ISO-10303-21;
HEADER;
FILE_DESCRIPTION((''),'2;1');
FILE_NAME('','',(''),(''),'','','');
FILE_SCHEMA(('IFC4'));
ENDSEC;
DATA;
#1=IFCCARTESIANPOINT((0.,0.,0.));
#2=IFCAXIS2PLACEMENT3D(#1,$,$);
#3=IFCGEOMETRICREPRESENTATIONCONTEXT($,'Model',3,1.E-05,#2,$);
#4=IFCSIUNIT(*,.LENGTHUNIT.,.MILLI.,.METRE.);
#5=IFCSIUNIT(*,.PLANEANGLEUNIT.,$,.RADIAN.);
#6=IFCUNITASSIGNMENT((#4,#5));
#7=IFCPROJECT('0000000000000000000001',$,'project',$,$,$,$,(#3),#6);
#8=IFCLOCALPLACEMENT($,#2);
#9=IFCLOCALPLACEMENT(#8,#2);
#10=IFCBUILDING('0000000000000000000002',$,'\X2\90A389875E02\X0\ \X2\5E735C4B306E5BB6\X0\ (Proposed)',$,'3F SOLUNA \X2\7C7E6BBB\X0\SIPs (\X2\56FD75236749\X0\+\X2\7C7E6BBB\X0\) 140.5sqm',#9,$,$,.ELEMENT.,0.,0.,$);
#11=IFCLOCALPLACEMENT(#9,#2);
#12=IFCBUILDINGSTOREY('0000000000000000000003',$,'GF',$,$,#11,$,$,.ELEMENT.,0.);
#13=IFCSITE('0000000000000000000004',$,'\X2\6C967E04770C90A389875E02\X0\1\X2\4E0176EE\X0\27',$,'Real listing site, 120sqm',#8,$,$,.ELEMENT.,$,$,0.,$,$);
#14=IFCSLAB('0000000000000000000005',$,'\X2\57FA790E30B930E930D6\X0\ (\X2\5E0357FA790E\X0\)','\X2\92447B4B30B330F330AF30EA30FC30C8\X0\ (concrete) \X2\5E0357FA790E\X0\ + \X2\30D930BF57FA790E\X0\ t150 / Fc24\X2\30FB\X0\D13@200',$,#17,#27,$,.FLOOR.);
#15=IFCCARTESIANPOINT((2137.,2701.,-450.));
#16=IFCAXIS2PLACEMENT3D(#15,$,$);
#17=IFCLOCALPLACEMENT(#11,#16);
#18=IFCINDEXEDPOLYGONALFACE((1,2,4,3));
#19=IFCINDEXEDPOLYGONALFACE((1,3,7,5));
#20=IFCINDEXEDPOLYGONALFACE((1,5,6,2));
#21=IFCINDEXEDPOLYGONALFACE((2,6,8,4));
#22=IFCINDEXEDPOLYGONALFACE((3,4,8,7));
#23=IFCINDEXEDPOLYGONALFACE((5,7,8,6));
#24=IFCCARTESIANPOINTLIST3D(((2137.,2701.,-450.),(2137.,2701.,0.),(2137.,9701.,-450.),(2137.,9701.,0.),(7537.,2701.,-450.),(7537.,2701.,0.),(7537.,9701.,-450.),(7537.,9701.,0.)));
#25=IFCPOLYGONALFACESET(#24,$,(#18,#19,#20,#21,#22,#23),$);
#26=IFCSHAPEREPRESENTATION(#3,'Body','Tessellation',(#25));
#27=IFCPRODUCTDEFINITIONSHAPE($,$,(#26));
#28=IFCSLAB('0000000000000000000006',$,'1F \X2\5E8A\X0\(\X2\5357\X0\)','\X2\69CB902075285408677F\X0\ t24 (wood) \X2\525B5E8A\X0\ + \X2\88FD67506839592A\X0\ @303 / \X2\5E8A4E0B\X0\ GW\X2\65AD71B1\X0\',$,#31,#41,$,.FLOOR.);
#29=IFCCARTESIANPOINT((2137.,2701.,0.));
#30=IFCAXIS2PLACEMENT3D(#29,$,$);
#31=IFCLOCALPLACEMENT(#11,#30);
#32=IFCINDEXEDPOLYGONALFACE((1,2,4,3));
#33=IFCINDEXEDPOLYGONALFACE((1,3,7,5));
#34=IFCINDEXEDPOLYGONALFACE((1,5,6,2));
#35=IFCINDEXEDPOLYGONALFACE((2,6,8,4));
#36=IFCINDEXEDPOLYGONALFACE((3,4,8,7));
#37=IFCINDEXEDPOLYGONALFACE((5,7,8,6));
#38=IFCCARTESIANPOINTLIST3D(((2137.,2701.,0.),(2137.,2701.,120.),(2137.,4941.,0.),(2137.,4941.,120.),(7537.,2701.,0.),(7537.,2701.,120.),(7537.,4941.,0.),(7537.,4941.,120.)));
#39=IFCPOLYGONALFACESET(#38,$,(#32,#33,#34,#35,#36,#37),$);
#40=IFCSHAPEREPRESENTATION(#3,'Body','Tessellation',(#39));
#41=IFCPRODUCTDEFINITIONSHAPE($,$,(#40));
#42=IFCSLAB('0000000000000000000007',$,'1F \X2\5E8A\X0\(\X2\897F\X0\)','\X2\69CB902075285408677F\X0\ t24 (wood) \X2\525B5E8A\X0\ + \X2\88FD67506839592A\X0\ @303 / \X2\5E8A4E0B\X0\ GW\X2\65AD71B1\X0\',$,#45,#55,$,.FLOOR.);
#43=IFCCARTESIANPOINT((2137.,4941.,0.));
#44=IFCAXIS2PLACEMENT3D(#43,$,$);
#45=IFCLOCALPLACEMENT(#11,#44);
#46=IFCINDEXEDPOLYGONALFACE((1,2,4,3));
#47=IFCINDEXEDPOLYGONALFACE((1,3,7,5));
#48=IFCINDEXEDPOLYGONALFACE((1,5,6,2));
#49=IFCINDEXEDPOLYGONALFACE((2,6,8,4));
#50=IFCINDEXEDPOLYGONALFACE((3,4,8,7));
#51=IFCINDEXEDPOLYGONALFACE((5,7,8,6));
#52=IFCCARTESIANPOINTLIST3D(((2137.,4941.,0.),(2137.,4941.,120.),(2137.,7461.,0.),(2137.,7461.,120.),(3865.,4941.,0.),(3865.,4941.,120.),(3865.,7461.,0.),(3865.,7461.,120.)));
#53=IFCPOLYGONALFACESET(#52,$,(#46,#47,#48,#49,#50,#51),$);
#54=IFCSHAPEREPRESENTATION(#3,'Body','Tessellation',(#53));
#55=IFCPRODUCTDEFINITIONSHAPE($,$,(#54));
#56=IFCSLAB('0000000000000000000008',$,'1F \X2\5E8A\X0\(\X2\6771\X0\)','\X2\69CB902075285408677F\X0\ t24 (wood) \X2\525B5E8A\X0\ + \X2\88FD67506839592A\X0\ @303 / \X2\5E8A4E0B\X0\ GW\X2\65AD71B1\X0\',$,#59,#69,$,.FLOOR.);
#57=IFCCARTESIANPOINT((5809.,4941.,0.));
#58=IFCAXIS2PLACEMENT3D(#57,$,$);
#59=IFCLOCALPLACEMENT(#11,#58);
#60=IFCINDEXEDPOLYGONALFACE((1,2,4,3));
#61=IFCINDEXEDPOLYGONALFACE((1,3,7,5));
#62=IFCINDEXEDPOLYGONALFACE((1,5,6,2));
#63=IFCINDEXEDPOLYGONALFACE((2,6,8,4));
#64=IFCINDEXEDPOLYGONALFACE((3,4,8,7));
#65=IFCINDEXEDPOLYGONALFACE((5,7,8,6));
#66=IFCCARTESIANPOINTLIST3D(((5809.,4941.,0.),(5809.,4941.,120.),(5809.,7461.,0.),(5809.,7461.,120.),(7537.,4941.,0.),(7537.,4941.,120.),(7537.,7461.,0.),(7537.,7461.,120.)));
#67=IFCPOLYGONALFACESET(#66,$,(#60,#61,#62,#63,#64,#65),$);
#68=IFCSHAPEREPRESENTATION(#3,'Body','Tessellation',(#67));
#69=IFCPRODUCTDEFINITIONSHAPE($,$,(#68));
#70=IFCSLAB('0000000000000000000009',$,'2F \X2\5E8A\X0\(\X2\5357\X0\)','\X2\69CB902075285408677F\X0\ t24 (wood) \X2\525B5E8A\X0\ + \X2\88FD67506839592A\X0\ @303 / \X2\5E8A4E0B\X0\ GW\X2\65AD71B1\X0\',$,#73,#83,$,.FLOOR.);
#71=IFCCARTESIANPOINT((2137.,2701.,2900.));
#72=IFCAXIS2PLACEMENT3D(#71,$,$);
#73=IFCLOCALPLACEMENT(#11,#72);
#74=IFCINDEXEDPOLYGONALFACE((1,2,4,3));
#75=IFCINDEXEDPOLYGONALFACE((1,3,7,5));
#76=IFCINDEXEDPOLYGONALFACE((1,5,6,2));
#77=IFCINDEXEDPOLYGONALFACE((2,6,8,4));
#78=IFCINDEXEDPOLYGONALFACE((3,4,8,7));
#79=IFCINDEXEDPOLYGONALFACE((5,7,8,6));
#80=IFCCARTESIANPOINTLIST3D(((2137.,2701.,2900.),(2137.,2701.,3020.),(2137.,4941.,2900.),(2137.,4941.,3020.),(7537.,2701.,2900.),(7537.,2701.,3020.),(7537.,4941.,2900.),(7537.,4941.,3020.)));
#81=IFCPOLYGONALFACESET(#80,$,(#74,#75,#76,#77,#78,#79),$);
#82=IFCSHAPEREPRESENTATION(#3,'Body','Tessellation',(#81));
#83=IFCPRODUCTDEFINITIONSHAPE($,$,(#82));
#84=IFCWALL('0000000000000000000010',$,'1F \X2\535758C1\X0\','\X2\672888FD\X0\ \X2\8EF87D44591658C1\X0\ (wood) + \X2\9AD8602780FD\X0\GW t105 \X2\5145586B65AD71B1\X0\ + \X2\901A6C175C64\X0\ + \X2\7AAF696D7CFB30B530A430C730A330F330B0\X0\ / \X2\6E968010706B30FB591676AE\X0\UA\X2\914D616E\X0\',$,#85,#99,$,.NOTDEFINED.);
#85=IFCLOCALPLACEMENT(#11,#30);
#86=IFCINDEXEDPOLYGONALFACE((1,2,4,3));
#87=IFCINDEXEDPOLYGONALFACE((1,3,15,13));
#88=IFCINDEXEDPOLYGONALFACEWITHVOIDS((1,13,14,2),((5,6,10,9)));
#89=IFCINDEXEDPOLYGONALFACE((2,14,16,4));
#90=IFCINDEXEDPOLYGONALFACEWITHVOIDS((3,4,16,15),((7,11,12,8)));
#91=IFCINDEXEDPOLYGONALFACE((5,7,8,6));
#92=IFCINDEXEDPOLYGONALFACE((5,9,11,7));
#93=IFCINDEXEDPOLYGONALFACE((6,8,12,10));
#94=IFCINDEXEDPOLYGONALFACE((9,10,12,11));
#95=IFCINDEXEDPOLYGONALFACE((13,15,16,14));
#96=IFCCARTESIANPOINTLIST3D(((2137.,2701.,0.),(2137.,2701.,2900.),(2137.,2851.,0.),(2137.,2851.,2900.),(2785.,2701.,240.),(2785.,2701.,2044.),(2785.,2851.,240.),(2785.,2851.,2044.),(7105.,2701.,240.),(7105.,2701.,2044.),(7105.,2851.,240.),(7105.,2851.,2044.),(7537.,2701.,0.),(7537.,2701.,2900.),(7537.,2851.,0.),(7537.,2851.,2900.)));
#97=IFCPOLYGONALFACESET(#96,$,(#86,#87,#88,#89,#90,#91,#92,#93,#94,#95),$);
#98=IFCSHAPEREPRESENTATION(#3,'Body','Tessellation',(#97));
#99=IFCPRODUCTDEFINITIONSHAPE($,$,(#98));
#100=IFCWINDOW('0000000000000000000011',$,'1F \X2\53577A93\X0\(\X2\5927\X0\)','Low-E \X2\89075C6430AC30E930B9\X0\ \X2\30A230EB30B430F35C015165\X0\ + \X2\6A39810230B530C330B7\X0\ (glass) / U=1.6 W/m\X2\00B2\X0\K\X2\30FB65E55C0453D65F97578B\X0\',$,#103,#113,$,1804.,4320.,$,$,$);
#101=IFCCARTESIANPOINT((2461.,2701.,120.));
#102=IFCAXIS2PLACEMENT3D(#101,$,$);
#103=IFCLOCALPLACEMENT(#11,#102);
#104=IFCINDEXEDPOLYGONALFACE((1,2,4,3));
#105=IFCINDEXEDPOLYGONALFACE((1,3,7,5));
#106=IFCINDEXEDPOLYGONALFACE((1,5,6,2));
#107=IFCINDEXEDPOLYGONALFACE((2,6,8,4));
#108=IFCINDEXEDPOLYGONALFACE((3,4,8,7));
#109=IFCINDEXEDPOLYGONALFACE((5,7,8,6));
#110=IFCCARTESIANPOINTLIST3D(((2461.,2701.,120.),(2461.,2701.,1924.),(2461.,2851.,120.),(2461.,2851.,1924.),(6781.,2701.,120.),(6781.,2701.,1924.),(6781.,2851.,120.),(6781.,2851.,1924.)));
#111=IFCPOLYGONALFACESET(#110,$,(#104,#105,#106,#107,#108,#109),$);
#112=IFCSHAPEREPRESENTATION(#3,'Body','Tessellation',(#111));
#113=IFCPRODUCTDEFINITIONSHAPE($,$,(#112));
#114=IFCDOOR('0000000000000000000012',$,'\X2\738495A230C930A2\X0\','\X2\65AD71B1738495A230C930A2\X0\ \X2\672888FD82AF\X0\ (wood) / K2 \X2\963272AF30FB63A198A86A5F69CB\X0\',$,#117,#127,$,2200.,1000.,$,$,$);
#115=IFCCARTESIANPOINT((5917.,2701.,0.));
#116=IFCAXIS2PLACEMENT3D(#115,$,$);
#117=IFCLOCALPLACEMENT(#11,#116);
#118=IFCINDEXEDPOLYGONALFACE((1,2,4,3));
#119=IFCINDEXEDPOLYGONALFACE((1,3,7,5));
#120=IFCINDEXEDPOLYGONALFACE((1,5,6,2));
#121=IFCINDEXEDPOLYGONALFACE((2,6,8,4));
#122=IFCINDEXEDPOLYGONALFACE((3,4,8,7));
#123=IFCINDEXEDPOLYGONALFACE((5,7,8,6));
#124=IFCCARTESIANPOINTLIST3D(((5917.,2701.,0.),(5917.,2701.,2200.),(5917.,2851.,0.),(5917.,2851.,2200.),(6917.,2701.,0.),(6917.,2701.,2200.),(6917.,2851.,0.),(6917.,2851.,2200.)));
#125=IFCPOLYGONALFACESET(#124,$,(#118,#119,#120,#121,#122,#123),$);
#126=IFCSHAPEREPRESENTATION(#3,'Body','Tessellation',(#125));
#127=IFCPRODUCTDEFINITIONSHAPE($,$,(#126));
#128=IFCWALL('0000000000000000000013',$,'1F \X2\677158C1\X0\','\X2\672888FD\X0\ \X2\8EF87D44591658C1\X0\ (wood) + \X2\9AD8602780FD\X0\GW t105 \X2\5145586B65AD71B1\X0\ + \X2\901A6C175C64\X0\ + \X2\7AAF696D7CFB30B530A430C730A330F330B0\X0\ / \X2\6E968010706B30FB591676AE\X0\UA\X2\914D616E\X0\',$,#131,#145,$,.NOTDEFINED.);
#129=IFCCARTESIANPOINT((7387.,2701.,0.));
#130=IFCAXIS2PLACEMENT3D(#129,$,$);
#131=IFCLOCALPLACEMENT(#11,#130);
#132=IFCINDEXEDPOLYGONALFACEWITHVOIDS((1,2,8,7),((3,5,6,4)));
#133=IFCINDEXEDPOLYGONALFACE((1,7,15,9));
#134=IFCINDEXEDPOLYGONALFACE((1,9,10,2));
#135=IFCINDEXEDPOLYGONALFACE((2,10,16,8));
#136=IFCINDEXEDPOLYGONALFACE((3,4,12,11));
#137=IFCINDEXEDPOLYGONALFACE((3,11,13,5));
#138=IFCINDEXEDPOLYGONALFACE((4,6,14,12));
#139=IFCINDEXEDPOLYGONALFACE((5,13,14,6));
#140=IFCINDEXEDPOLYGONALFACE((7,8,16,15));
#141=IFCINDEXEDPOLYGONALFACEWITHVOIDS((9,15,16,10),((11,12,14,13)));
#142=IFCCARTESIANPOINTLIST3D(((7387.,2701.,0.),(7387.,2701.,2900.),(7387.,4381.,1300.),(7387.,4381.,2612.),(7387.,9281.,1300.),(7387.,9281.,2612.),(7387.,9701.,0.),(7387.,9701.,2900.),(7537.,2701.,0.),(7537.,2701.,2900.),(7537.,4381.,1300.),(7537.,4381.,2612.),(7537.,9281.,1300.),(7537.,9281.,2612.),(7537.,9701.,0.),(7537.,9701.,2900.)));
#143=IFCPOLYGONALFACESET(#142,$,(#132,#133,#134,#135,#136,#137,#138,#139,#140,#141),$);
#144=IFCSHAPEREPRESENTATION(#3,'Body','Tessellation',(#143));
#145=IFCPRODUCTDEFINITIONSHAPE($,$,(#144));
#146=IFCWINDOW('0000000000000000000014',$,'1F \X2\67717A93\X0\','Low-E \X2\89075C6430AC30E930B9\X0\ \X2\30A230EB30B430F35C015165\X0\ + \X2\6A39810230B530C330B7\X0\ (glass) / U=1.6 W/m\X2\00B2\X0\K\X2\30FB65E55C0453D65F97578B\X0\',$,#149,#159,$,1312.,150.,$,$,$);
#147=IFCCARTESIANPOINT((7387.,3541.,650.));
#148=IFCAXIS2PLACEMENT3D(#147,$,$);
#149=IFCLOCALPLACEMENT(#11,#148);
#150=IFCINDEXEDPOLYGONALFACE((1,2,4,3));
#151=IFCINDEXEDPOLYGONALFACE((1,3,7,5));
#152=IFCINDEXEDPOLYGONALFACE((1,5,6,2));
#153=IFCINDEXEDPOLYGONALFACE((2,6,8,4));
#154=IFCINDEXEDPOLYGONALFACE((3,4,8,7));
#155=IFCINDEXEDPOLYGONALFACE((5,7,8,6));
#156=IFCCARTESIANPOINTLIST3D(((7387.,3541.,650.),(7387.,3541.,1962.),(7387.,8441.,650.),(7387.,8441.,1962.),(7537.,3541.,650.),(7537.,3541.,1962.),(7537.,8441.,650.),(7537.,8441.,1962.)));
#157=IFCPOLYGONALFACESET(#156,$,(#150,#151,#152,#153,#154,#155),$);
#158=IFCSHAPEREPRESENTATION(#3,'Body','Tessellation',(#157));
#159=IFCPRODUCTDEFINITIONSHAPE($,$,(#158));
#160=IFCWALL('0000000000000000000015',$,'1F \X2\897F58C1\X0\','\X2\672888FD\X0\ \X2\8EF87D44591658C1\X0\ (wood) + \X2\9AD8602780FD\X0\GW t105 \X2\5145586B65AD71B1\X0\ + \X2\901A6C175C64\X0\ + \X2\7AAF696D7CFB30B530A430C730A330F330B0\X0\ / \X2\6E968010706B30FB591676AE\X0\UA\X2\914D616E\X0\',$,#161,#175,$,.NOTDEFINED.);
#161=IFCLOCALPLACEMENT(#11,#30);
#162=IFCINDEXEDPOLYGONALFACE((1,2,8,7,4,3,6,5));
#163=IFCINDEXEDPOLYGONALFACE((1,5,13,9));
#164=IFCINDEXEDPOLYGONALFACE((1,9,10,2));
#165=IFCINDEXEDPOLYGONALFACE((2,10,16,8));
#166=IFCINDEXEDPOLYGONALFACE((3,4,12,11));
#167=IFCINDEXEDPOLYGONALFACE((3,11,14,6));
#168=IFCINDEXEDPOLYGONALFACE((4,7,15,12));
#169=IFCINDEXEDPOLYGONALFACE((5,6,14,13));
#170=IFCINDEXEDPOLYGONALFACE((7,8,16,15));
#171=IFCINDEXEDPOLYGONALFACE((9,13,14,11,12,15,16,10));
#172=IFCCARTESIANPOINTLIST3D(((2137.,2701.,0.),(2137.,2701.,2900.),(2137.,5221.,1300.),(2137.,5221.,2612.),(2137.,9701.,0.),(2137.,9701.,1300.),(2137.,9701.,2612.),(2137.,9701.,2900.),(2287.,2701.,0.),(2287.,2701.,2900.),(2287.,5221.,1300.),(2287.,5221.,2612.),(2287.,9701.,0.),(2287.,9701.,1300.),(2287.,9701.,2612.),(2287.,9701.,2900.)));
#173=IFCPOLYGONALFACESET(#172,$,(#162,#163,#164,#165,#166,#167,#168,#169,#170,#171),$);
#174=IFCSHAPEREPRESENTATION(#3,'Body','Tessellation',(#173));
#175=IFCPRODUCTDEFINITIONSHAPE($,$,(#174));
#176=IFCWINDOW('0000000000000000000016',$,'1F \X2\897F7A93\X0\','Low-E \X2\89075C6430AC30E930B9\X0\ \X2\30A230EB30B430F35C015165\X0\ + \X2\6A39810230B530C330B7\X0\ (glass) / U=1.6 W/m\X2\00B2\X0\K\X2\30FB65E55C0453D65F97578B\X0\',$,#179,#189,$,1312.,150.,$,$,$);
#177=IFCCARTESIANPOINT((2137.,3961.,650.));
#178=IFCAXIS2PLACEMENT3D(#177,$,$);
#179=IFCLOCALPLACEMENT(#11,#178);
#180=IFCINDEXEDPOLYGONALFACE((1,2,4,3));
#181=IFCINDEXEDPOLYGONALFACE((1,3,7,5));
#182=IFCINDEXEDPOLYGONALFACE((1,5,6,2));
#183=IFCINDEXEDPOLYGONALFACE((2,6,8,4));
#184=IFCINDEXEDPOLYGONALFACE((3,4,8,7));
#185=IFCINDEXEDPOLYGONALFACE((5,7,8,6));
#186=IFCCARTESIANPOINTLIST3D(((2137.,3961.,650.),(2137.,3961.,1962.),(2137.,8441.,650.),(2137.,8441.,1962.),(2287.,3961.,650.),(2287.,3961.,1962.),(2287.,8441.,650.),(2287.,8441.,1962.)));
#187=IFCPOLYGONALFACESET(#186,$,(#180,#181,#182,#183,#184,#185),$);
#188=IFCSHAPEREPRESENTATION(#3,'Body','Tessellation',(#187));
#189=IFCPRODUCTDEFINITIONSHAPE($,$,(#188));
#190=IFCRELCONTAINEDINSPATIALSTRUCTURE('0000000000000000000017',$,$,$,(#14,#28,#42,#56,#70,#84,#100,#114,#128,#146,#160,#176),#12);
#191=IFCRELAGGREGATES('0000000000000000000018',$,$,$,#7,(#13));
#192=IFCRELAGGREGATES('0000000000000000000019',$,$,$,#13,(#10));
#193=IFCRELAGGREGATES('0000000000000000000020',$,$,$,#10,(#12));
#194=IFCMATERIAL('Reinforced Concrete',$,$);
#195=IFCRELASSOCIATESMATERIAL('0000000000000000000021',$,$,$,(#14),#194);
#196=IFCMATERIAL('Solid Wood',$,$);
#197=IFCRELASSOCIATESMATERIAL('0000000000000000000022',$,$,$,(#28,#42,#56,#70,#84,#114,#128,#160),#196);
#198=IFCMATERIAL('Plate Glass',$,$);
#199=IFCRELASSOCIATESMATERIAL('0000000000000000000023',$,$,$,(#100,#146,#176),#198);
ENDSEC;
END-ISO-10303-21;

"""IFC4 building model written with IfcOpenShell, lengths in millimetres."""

from ifc_helpers import new_model, si_unit, frame, frame_2d, origin, place, context, project, spatial, rectangle, extrude, material, element, fill, save


model = new_model("IFC4")

# Units and contexts
model_context = context("Model", 3, precision=1e-05, world=origin())
ifc_project = project(units=[si_unit("LENGTHUNIT", "METRE", prefix="MILLI"), si_unit("PLANEANGLEUNIT", "RADIAN")], contexts=[model_context])

# Site, building, storey
site_placement = place(None, origin())
site = spatial("IfcSite", under=ifc_project, at=site_placement, Name="沖縄県那覇市1丁目27", ObjectType="Real listing site, 120sqm", CompositionType="ELEMENT", RefElevation=0.0)
building_placement = place(site_placement, origin())
building = spatial("IfcBuilding", under=site, at=building_placement, Name="那覇市 平屋の家 (Proposed)", ObjectType="3F SOLUNA 籾殻SIPs (国産杉+籾殻) 140.5sqm", CompositionType="ELEMENT", ElevationOfRefHeight=0.0, ElevationOfTerrain=0.0)
storey_placement = place(building_placement, origin())
storey = spatial("IfcBuildingStorey", under=building, at=storey_placement, Name="GF", CompositionType="ELEMENT", Elevation=0.0)

# Slabs
ifc_material_1 = material(Name="Reinforced Concrete")
slab_1_placement = place(storey_placement, frame((2137.0, 2701.0, -450.0)))
element("IfcSlab", 1, at=slab_1_placement, inside=storey, material=ifc_material_1, Name="基礎スラブ (布基礎)", Description="鉄筋コンクリート (concrete) 布基礎 + ベタ基礎 t150 / Fc24・D13@200", PredefinedType="FLOOR", context=model_context, shape_type="SweptSolid", body=[
    extrude(rectangle(XDim=5400.0, YDim=7000.0, at=frame_2d((2700.0, 3500.0))), frame((2137.0, 2701.0, -450.0)), (0.0, 0.0, 1.0), 450.0),
])
ifc_material_2 = material(Name="Solid Wood")
slab_2_placement = place(storey_placement, frame((2137.0, 2701.0, 0.0)))
element("IfcSlab", 2, at=slab_2_placement, inside=storey, material=ifc_material_2, Name="1F 床(南)", Description="構造用合板 t24 (wood) 剛床 + 製材根太 @303 / 床下 GW断熱", PredefinedType="FLOOR", context=model_context, shape_type="SweptSolid", body=[
    extrude(rectangle(XDim=5400.0, YDim=2240.0, at=frame_2d((2700.0, 1120.0))), frame((2137.0, 2701.0, 0.0)), (0.0, 0.0, 1.0), 120.0),
])
slab_3_placement = place(storey_placement, frame((2137.0, 4941.0, 0.0)))
element("IfcSlab", 3, at=slab_3_placement, inside=storey, material=ifc_material_2, Name="1F 床(西)", Description="構造用合板 t24 (wood) 剛床 + 製材根太 @303 / 床下 GW断熱", PredefinedType="FLOOR", context=model_context, shape_type="SweptSolid", body=[
    extrude(rectangle(XDim=1728.0, YDim=2520.0, at=frame_2d((864.0, 1260.0))), frame((2137.0, 4941.0, 0.0)), (0.0, 0.0, 1.0), 120.0),
])
slab_4_placement = place(storey_placement, frame((5809.0, 4941.0, 0.0)))
element("IfcSlab", 4, at=slab_4_placement, inside=storey, material=ifc_material_2, Name="1F 床(東)", Description="構造用合板 t24 (wood) 剛床 + 製材根太 @303 / 床下 GW断熱", PredefinedType="FLOOR", context=model_context, shape_type="SweptSolid", body=[
    extrude(rectangle(XDim=1728.0, YDim=2520.0, at=frame_2d((864.0, 1260.0))), frame((5809.0, 4941.0, 0.0)), (0.0, 0.0, 1.0), 120.0),
])
slab_5_placement = place(storey_placement, frame((2137.0, 2701.0, 2900.0)))
element("IfcSlab", 5, at=slab_5_placement, inside=storey, material=ifc_material_2, Name="2F 床(南)", Description="構造用合板 t24 (wood) 剛床 + 製材根太 @303 / 床下 GW断熱", PredefinedType="FLOOR", context=model_context, shape_type="SweptSolid", body=[
    extrude(rectangle(XDim=5400.0, YDim=2240.0, at=frame_2d((2700.0, 1120.0))), frame((2137.0, 2701.0, 2900.0)), (0.0, 0.0, 1.0), 120.0),
])

# Wall, openings, window, door
wall_1_placement = place(storey_placement, frame((2137.0, 2701.0, 0.0)))
wall_1 = element("IfcWall", 6, at=wall_1_placement, inside=storey, material=ifc_material_2, Name="1F 南壁", Description="木製 軸組外壁 (wood) + 高性能GW t105 充填断熱 + 通気層 + 窯業系サイディング / 準耐火・外皮UA配慮", PredefinedType="NOTDEFINED", context=model_context, shape_type="SweptSolid", body=[
    extrude(rectangle(XDim=5400.0, YDim=150.0, at=frame_2d((2700.0, 75.0))), frame((2137.0, 2701.0, 0.0)), (0.0, 0.0, 1.0), 2900.0),
])
opening_1_placement = place(storey_placement, frame((2461.0, 2701.0, 120.0)))
opening_1 = element("IfcOpeningElement", 7, at=opening_1_placement, cuts=wall_1, PredefinedType="NOTDEFINED", context=model_context, shape_type="SweptSolid", body=[
    extrude(rectangle(XDim=4320.0, YDim=150.0, at=frame_2d((2160.0, 75.0))), frame((2461.0, 2701.0, 120.0)), (0.0, 0.0, 1.0), 1804.0),
])
opening_2_placement = place(storey_placement, frame((5917.0, 2701.0, 0.0)))
opening_2 = element("IfcOpeningElement", 8, at=opening_2_placement, cuts=wall_1, PredefinedType="NOTDEFINED", context=model_context, shape_type="SweptSolid", body=[
    extrude(rectangle(XDim=1000.0, YDim=150.0, at=frame_2d((500.0, 75.0))), frame((5917.0, 2701.0, 0.0)), (0.0, 0.0, 1.0), 2200.0),
])
ifc_material_3 = material(Name="Plate Glass")
window_1_placement = place(storey_placement, frame((2461.0, 2701.0, 120.0)))
window_1 = element("IfcWindow", 9, at=window_1_placement, inside=storey, material=ifc_material_3, Name="1F 南窓(大)", Description="Low-E 複層ガラス アルゴン封入 + 樹脂サッシ (glass) / U=1.6 W/m²K・日射取得型", OverallHeight=1804.0, OverallWidth=4320.0, context=model_context, shape_type="SweptSolid", body=[
    extrude(rectangle(XDim=4320.0, YDim=150.0, at=frame_2d((2160.0, 75.0))), frame((2461.0, 2701.0, 120.0)), (0.0, 0.0, 1.0), 1804.0),
])
fill(opening_1, window_1)
door_placement = place(storey_placement, frame((5917.0, 2701.0, 0.0)))
door = element("IfcDoor", 10, at=door_placement, inside=storey, material=ifc_material_2, Name="玄関ドア", Description="断熱玄関ドア 木製芯 (wood) / K2 防犯・採風機構", OverallHeight=2200.0, OverallWidth=1000.0, context=model_context, shape_type="SweptSolid", body=[
    extrude(rectangle(XDim=1000.0, YDim=150.0, at=frame_2d((500.0, 75.0))), frame((5917.0, 2701.0, 0.0)), (0.0, 0.0, 1.0), 2200.0),
])
fill(opening_2, door)

# Walls, openings, windows
wall_2_placement = place(storey_placement, frame((7387.0, 2701.0, 0.0)))
wall_2 = element("IfcWall", 11, at=wall_2_placement, inside=storey, material=ifc_material_2, Name="1F 東壁", Description="木製 軸組外壁 (wood) + 高性能GW t105 充填断熱 + 通気層 + 窯業系サイディング / 準耐火・外皮UA配慮", PredefinedType="NOTDEFINED", context=model_context, shape_type="SweptSolid", body=[
    extrude(rectangle(XDim=150.0, YDim=7000.0, at=frame_2d((75.0, 3500.0))), frame((7387.0, 2701.0, 0.0)), (0.0, 0.0, 1.0), 2900.0),
])
opening_3_placement = place(storey_placement, frame((7387.0, 3541.0, 650.0)))
opening_3 = element("IfcOpeningElement", 12, at=opening_3_placement, cuts=wall_2, PredefinedType="NOTDEFINED", context=model_context, shape_type="SweptSolid", body=[
    extrude(rectangle(XDim=150.0, YDim=4900.0, at=frame_2d((75.0, 2450.0))), frame((7387.0, 3541.0, 650.0)), (0.0, 0.0, 1.0), 1312.0),
])
window_2_placement = place(storey_placement, frame((7387.0, 3541.0, 650.0)))
window_2 = element("IfcWindow", 13, at=window_2_placement, inside=storey, material=ifc_material_3, Name="1F 東窓", Description="Low-E 複層ガラス アルゴン封入 + 樹脂サッシ (glass) / U=1.6 W/m²K・日射取得型", OverallHeight=1312.0, OverallWidth=150.0, context=model_context, shape_type="SweptSolid", body=[
    extrude(rectangle(XDim=150.0, YDim=4900.0, at=frame_2d((75.0, 2450.0))), frame((7387.0, 3541.0, 650.0)), (0.0, 0.0, 1.0), 1312.0),
])
fill(opening_3, window_2)
wall_3_placement = place(storey_placement, frame((2137.0, 2701.0, 0.0)))
wall_3 = element("IfcWall", 14, at=wall_3_placement, inside=storey, material=ifc_material_2, Name="1F 西壁", Description="木製 軸組外壁 (wood) + 高性能GW t105 充填断熱 + 通気層 + 窯業系サイディング / 準耐火・外皮UA配慮", PredefinedType="NOTDEFINED", context=model_context, shape_type="SweptSolid", body=[
    extrude(rectangle(XDim=150.0, YDim=7000.0, at=frame_2d((75.0, 3500.0))), frame((2137.0, 2701.0, 0.0)), (0.0, 0.0, 1.0), 2900.0),
])
opening_4_placement = place(storey_placement, frame((2137.0, 3961.0, 650.0)))
opening_4 = element("IfcOpeningElement", 15, at=opening_4_placement, cuts=wall_3, PredefinedType="NOTDEFINED", context=model_context, shape_type="SweptSolid", body=[
    extrude(rectangle(XDim=150.0, YDim=4480.0, at=frame_2d((75.0, 2240.0))), frame((2137.0, 3961.0, 650.0)), (0.0, 0.0, 1.0), 1312.0),
])
window_3_placement = place(storey_placement, frame((2137.0, 3961.0, 650.0)))
window_3 = element("IfcWindow", 16, at=window_3_placement, inside=storey, material=ifc_material_3, Name="1F 西窓", Description="Low-E 複層ガラス アルゴン封入 + 樹脂サッシ (glass) / U=1.6 W/m²K・日射取得型", OverallHeight=1312.0, OverallWidth=150.0, context=model_context, shape_type="SweptSolid", body=[
    extrude(rectangle(XDim=150.0, YDim=4480.0, at=frame_2d((75.0, 2240.0))), frame((2137.0, 3961.0, 650.0)), (0.0, 0.0, 1.0), 1312.0),
])
fill(opening_4, window_3)

save(model, "model.ifc")
